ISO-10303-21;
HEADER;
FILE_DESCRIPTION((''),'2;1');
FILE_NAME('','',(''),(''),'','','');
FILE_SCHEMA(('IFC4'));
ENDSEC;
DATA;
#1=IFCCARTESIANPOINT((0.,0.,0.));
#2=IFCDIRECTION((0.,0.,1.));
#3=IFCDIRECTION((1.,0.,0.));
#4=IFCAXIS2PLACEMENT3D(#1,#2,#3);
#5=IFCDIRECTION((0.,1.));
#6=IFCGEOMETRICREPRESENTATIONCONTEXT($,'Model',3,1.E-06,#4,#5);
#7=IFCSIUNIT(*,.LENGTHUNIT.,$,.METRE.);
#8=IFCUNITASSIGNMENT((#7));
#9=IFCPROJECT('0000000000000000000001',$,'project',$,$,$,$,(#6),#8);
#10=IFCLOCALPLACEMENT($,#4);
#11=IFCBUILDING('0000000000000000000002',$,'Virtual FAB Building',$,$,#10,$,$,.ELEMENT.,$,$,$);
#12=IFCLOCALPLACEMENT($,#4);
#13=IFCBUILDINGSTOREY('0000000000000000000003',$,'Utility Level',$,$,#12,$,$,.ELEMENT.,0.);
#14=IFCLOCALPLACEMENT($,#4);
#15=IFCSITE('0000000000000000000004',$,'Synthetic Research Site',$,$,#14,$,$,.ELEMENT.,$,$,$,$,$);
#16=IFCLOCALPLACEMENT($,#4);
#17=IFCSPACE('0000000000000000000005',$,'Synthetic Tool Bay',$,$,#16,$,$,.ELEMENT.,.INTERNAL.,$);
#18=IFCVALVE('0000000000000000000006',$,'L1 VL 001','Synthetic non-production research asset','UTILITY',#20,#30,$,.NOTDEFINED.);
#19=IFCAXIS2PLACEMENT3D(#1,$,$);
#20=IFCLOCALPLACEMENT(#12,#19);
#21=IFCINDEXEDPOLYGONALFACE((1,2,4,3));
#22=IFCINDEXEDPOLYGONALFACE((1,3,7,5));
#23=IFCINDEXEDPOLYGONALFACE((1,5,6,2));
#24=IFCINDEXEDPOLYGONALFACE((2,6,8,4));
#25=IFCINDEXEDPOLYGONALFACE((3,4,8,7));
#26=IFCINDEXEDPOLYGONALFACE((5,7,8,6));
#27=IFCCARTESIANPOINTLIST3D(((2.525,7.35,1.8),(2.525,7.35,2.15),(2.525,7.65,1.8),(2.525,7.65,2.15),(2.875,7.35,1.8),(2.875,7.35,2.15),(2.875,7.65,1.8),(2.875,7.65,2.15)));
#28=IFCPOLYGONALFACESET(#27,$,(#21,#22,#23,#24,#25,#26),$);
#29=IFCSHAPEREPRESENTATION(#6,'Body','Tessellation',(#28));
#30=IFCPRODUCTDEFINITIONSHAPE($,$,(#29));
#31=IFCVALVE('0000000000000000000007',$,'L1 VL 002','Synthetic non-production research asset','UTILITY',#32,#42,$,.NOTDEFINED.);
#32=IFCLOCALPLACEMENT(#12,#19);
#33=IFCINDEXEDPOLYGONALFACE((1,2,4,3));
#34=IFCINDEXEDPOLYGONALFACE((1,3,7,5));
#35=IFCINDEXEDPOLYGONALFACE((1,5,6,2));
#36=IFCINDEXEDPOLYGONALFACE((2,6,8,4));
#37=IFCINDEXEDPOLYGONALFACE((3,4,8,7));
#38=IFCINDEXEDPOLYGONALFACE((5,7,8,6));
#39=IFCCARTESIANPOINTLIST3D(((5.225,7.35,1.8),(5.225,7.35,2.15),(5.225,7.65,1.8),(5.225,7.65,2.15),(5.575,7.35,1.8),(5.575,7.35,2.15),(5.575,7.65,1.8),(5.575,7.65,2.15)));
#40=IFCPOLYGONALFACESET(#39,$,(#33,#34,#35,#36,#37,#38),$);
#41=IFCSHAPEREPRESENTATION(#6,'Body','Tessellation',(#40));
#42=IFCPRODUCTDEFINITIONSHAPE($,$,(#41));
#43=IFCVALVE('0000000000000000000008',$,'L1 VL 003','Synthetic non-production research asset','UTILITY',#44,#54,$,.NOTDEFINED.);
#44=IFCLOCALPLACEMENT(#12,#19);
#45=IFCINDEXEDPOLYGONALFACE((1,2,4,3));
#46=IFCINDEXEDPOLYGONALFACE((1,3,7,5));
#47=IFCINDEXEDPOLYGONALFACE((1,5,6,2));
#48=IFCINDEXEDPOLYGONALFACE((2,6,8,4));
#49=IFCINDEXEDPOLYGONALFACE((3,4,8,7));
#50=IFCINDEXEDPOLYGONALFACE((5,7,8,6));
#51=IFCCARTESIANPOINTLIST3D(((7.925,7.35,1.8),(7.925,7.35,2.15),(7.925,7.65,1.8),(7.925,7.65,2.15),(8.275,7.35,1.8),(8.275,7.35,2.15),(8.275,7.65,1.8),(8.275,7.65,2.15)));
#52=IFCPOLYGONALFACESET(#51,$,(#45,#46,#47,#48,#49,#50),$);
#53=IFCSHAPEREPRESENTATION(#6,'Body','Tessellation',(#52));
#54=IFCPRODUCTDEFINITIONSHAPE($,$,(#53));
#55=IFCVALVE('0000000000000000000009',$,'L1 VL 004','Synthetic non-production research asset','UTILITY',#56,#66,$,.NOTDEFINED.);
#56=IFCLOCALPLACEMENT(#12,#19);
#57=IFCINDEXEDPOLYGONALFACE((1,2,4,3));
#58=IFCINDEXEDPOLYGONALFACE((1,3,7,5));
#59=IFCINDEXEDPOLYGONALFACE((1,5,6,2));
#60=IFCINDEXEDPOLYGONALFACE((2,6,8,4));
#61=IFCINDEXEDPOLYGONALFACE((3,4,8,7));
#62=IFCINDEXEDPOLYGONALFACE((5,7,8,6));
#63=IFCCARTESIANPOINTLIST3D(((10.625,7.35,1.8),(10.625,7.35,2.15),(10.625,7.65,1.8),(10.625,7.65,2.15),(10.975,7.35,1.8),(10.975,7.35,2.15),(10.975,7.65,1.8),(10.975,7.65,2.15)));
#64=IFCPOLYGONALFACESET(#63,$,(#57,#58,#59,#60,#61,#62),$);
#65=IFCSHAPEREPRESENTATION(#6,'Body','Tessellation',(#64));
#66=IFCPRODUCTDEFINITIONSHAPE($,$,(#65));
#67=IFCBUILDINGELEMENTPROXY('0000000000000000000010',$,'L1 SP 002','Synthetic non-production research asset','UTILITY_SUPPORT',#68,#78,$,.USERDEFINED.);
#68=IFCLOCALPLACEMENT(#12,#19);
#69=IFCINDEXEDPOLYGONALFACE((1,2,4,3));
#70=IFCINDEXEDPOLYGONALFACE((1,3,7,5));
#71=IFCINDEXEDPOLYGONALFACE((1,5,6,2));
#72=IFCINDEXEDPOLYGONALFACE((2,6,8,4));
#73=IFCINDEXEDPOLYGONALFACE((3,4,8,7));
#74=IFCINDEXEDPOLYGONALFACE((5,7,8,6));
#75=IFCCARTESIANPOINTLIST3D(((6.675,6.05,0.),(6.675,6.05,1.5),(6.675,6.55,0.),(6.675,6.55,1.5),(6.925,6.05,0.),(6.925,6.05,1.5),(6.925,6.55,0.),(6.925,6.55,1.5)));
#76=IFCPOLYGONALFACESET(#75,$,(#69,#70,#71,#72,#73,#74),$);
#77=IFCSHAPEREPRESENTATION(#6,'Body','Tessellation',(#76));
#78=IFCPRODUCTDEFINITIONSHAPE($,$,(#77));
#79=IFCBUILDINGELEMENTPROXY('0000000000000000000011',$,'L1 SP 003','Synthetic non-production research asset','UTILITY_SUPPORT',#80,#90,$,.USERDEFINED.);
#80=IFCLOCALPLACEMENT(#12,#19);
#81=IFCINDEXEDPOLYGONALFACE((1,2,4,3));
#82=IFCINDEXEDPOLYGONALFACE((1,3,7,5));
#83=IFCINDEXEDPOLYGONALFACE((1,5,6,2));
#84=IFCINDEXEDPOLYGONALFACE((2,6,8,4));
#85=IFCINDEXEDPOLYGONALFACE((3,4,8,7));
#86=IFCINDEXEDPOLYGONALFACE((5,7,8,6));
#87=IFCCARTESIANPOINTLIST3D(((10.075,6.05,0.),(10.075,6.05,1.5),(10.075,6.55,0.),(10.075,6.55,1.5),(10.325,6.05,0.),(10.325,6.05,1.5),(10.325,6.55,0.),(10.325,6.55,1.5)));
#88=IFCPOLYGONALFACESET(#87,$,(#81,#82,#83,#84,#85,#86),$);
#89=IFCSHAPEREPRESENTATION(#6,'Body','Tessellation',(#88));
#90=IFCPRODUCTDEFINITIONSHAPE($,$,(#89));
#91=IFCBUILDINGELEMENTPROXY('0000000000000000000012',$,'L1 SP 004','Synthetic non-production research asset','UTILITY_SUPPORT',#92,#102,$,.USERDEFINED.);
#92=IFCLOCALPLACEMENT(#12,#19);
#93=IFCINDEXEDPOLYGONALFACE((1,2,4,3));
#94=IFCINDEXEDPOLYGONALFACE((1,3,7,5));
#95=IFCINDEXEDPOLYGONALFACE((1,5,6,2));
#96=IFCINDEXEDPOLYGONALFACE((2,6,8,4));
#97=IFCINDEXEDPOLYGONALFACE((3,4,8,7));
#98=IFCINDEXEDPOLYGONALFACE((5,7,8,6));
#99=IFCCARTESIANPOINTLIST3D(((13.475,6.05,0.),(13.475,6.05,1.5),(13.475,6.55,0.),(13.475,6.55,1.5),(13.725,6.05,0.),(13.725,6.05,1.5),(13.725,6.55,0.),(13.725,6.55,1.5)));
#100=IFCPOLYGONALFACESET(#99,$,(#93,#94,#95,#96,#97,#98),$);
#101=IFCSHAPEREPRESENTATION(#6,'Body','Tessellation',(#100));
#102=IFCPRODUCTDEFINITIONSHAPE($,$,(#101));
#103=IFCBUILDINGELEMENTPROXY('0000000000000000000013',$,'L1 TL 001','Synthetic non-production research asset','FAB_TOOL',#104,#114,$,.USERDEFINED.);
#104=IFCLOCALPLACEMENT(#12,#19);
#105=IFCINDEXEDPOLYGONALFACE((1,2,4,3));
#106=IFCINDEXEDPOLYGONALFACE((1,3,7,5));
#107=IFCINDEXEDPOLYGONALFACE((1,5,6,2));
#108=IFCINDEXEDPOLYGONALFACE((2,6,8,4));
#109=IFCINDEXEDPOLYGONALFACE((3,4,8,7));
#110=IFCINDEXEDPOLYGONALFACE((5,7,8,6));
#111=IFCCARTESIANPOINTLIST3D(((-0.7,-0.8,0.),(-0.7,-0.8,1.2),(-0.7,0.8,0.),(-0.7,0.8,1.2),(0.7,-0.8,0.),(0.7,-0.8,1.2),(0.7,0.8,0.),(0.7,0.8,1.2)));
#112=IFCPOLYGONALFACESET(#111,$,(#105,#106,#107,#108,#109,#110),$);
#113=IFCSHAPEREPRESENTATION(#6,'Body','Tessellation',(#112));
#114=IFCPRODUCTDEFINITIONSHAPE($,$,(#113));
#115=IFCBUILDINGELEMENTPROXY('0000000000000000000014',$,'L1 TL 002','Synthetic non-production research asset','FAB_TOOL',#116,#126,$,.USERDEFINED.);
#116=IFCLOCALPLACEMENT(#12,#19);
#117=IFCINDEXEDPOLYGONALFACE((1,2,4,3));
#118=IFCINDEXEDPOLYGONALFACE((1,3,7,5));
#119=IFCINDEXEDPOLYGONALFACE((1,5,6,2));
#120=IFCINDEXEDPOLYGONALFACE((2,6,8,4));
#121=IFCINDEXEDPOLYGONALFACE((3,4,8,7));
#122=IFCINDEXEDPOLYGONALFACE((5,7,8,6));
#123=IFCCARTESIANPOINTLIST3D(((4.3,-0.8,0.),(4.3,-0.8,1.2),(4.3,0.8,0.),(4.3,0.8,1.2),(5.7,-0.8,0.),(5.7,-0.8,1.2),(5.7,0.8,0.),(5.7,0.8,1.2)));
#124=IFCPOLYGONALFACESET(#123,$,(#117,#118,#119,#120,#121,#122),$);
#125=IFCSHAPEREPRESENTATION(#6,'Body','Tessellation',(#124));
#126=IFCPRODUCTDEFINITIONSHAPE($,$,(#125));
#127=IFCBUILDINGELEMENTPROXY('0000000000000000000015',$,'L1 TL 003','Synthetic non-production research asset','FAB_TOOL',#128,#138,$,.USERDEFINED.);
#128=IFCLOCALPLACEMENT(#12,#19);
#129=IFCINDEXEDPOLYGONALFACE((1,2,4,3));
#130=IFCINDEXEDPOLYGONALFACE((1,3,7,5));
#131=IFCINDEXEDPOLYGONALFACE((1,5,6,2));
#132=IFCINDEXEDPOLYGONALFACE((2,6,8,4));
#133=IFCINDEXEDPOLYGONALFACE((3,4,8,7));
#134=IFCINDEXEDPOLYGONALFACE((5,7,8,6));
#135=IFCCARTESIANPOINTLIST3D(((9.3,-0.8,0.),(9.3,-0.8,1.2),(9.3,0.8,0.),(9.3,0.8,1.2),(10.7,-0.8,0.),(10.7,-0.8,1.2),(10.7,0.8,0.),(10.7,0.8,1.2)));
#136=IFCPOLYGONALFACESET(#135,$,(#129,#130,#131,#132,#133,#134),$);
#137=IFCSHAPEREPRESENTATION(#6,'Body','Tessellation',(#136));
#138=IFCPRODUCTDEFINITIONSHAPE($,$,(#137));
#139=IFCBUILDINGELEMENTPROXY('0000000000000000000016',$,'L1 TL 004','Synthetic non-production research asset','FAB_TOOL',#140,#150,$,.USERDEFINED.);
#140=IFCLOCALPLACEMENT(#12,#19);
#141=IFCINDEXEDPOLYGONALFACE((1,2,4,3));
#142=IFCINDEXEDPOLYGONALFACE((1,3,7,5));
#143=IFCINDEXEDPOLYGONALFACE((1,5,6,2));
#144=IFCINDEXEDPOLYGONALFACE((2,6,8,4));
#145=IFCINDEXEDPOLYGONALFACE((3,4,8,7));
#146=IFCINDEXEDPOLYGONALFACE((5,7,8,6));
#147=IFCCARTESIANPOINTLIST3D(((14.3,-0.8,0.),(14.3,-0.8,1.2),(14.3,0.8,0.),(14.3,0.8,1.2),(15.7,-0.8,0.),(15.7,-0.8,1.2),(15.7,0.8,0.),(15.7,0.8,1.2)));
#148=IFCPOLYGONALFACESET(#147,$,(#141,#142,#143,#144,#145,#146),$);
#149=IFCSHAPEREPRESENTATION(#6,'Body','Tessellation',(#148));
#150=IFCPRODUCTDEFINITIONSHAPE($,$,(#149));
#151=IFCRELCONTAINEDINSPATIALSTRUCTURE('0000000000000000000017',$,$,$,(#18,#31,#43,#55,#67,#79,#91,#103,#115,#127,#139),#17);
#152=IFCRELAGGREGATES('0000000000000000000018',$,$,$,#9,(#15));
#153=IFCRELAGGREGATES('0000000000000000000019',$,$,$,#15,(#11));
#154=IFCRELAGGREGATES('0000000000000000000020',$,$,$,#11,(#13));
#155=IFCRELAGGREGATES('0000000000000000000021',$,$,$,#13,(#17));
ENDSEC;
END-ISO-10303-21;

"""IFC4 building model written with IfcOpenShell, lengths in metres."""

from ifc_helpers import new_model, si_unit, direction, frame, origin_with_axes, origin_2d_with_axis, place, context, project, spatial, rectangle, extrude, element, save


model = new_model("IFC4")

# Units and contexts
model_context = context("Model", 3, precision=1e-06, world=origin_with_axes(), true_north=direction((0.0, 1.0)))
ifc_project = project(units=[si_unit("LENGTHUNIT", "METRE")], contexts=[model_context])

# Site, building, storey, space
site_placement = place(None, origin_with_axes())
site = spatial("IfcSite", under=ifc_project, at=site_placement, Name="Synthetic Research Site", CompositionType="ELEMENT")
building_placement = place(None, origin_with_axes())
building = spatial("IfcBuilding", under=site, at=building_placement, Name="Virtual FAB Building", CompositionType="ELEMENT")
storey_placement = place(None, origin_with_axes())
storey = spatial("IfcBuildingStorey", under=building, at=storey_placement, Name="Utility Level", CompositionType="ELEMENT", Elevation=0.0)
space_placement = place(None, origin_with_axes())
space = spatial("IfcSpace", under=storey, at=space_placement, Name="Synthetic Tool Bay", CompositionType="ELEMENT", PredefinedType="INTERNAL")

# Valves
for number, where, z_axis, x_axis, name in (
    (1, (2.7, 7.5, 1.8), (0.0, 0.0, 1.0), (1.0, 0.0, 0.0), "L1 VL 001"),
    (2, (5.4, 7.5, 1.8), (0.0, 0.0, 1.0), (1.0, 0.0, 0.0), "L1 VL 002"),
    (3, (8.1, 7.5, 1.8), (0.0, 0.0, 1.0), (1.0, 0.0, 0.0), "L1 VL 003"),
    (4, (10.8, 7.5, 1.8), (0.0, 0.0, 1.0), (1.0, 0.0, 0.0), "L1 VL 004"),
):
    element("IfcValve", number, at=place(None, frame(where, z_axis=z_axis, x_axis=x_axis)), inside=space, Name=name, Description="Synthetic non-production research asset", ObjectType="UTILITY", PredefinedType="NOTDEFINED", context=model_context, shape_type="SweptSolid", body=[
        extrude(rectangle(XDim=0.35, YDim=0.3, at=origin_2d_with_axis()), origin_with_axes(), (0.0, 0.0, 1.0), 0.35),
    ])

# Building element proxies
for number, where, z_axis, x_axis, name in (
    (5, (6.8, 6.3, 0.0), (0.0, 0.0, 1.0), (1.0, 0.0, 0.0), "L1 SP 002"),
    (6, (10.2, 6.3, 0.0), (0.0, 0.0, 1.0), (1.0, 0.0, 0.0), "L1 SP 003"),
    (7, (13.6, 6.3, 0.0), (0.0, 0.0, 1.0), (1.0, 0.0, 0.0), "L1 SP 004"),
):
    element("IfcBuildingElementProxy", number, at=place(None, frame(where, z_axis=z_axis, x_axis=x_axis)), inside=space, Name=name, Description="Synthetic non-production research asset", ObjectType="UTILITY_SUPPORT", PredefinedType="USERDEFINED", context=model_context, shape_type="SweptSolid", body=[
        extrude(rectangle(XDim=0.25, YDim=0.5, at=origin_2d_with_axis()), origin_with_axes(), (0.0, 0.0, 1.0), 1.5),
    ])
for number, where, z_axis, x_axis, name in (
    (8, (0.0, 0.0, 0.0), (0.0, 0.0, 1.0), (1.0, 0.0, 0.0), "L1 TL 001"),
    (9, (5.0, 0.0, 0.0), (0.0, 0.0, 1.0), (1.0, 0.0, 0.0), "L1 TL 002"),
    (10, (10.0, 0.0, 0.0), (0.0, 0.0, 1.0), (1.0, 0.0, 0.0), "L1 TL 003"),
    (11, (15.0, 0.0, 0.0), (0.0, 0.0, 1.0), (1.0, 0.0, 0.0), "L1 TL 004"),
):
    element("IfcBuildingElementProxy", number, at=place(None, frame(where, z_axis=z_axis, x_axis=x_axis)), inside=space, Name=name, Description="Synthetic non-production research asset", ObjectType="FAB_TOOL", PredefinedType="USERDEFINED", context=model_context, shape_type="SweptSolid", body=[
        extrude(rectangle(XDim=1.4, YDim=1.6, at=origin_2d_with_axis()), origin_with_axes(), (0.0, 0.0, 1.0), 1.2),
    ])

save(model, "model.ifc")
